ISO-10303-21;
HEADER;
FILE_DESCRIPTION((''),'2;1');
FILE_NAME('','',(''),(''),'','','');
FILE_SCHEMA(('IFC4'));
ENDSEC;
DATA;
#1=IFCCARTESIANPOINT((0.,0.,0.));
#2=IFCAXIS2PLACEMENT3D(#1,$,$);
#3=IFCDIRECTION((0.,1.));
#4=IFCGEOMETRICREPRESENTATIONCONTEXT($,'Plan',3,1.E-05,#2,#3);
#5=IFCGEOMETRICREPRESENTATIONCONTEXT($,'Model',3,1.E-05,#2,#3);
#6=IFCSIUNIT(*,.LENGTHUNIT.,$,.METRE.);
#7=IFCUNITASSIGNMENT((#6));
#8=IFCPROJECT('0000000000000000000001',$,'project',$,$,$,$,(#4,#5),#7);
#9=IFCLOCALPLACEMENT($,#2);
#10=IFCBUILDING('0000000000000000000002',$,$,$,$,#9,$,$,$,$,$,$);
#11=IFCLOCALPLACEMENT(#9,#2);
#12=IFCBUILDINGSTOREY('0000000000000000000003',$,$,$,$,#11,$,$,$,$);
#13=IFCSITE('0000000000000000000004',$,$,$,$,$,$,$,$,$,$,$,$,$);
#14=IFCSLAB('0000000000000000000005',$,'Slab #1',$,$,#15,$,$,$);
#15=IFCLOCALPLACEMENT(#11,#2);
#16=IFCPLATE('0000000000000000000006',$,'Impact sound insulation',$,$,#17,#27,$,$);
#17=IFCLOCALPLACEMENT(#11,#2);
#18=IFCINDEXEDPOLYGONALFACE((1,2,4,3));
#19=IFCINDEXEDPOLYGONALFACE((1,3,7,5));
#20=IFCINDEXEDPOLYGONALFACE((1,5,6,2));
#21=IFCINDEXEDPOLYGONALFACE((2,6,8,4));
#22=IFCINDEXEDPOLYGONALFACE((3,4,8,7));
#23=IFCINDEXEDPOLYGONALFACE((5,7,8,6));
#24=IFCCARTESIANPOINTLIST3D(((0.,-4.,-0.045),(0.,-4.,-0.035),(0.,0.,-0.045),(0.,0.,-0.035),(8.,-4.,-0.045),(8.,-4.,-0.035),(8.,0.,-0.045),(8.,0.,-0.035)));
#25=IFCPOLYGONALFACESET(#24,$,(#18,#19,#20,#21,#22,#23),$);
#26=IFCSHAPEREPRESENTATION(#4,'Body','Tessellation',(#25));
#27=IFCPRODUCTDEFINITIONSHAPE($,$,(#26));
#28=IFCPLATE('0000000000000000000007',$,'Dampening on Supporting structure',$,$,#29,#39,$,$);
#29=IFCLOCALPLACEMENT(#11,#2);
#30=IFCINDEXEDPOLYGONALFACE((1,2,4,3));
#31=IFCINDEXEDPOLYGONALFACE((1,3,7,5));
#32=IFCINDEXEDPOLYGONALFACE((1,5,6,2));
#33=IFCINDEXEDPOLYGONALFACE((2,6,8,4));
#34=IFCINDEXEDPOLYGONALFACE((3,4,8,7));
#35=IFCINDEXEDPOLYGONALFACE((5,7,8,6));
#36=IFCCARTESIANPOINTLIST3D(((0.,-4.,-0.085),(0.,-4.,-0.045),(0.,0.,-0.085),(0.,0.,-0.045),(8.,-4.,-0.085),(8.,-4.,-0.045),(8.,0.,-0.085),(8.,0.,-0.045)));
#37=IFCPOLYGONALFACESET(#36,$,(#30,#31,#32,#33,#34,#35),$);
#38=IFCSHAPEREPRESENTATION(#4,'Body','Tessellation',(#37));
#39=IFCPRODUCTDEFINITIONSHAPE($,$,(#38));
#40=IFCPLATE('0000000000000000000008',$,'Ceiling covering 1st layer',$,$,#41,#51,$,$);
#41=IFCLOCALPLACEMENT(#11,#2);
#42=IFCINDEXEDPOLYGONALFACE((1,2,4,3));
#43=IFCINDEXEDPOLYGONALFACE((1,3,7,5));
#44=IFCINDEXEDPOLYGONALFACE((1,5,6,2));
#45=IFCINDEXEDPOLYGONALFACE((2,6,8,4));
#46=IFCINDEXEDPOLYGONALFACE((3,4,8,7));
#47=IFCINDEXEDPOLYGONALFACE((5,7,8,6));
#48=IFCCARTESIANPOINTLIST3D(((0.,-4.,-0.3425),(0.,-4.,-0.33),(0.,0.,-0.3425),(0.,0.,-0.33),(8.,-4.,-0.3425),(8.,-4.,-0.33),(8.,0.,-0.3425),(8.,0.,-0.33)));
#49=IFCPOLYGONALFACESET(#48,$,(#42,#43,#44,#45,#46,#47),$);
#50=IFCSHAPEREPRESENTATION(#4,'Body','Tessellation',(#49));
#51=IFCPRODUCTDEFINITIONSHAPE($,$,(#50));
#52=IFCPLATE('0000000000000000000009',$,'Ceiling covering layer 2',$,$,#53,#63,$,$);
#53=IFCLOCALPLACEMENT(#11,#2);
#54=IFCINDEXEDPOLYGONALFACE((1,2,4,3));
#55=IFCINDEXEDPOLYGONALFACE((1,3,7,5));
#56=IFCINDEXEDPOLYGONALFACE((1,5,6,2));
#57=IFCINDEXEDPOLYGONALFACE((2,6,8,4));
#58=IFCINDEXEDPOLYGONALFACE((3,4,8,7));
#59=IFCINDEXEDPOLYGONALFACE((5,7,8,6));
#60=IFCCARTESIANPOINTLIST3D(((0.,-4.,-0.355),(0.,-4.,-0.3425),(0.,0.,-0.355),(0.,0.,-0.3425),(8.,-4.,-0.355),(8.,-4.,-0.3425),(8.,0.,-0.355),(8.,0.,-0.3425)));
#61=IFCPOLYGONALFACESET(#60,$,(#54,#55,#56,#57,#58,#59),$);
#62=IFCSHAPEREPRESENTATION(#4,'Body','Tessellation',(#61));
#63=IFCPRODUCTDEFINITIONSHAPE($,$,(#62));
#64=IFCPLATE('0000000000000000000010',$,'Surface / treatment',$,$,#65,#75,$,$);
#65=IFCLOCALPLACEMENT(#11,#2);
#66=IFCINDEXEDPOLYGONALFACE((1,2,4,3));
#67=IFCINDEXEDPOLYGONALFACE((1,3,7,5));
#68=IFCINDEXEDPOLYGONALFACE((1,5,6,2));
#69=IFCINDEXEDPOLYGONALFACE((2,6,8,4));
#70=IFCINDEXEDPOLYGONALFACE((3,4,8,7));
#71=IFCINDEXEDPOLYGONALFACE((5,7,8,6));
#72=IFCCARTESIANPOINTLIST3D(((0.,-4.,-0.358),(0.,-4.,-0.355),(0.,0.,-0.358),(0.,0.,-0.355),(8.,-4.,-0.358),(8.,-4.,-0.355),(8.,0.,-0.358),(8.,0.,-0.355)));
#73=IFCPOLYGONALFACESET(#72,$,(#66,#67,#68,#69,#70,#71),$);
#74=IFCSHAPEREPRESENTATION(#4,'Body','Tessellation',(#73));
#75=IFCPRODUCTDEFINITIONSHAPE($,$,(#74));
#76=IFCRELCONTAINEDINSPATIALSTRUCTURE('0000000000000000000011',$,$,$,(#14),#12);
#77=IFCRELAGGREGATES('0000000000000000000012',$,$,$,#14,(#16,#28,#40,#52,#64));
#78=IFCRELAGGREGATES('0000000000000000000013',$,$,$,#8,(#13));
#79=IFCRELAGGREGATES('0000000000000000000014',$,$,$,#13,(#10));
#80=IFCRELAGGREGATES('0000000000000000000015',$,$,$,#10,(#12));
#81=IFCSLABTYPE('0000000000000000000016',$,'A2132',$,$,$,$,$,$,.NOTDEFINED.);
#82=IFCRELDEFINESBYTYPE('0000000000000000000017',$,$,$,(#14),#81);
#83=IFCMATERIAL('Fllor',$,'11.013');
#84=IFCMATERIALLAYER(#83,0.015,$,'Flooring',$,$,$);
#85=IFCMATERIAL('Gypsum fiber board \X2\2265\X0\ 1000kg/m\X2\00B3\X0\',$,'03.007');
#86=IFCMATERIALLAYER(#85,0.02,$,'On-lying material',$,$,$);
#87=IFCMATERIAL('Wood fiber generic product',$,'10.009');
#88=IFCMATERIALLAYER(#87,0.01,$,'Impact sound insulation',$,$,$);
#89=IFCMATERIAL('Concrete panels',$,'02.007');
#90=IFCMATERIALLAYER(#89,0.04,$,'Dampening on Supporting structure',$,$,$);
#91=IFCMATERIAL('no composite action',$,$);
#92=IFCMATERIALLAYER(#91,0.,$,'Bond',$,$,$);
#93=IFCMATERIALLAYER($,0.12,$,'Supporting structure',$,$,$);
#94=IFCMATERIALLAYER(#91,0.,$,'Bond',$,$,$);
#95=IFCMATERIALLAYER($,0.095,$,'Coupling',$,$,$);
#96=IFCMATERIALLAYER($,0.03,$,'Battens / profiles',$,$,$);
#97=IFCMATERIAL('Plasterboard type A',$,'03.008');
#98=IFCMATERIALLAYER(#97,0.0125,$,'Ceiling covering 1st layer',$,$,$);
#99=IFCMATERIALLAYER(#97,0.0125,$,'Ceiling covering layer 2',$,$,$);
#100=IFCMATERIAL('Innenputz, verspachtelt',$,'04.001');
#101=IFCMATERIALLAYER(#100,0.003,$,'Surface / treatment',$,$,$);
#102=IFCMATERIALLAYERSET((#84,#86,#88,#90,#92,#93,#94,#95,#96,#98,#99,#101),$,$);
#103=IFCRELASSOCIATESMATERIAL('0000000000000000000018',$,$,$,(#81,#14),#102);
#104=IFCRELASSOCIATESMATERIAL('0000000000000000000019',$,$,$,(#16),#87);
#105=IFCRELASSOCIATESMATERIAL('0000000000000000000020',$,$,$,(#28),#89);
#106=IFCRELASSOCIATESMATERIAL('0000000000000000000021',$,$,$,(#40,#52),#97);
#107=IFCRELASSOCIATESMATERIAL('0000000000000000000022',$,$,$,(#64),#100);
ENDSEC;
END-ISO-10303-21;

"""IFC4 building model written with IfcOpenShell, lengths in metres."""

from ifc_helpers import new_model, si_unit, direction, frame, frame_2d, origin, place, context, project, spatial, rectangle, extrude, material, layer, layer_set, type_object, element, aggregate, save


model = new_model("IFC4")

# Units and contexts
plan_context = context("Plan", 3, precision=1e-05, world=origin(), true_north=direction((0.0, 1.0)))
model_context = context("Model", 3, precision=1e-05, world=origin(), true_north=direction((0.0, 1.0)))
ifc_project = project(units=[si_unit("LENGTHUNIT", "METRE")], contexts=[plan_context, model_context])

# Site, building, storey
site = spatial("IfcSite", under=ifc_project)
building_placement = place(None, origin())
building = spatial("IfcBuilding", under=site, at=building_placement)
storey_placement = place(building_placement, origin())
storey = spatial("IfcBuildingStorey", under=building, at=storey_placement)

# Slab, plates
ifc_material_1 = material(Name="Fllor", Category="11.013")
ifc_layer_1 = layer(ifc_material_1, 0.015, Name="Flooring")
ifc_material_2 = material(Name="Gypsum fiber board ≥ 1000kg/m³", Category="03.007")
ifc_layer_2 = layer(ifc_material_2, 0.02, Name="On-lying material")
ifc_material_3 = material(Name="Wood fiber generic product", Category="10.009")
ifc_layer_3 = layer(ifc_material_3, 0.01, Name="Impact sound insulation")
ifc_material_4 = material(Name="Concrete panels", Category="02.007")
ifc_layer_4 = layer(ifc_material_4, 0.04, Name="Dampening on Supporting structure")
ifc_material_5 = material(Name="no composite action")
ifc_layer_5 = layer(ifc_material_5, 0.0, Name="Bond")
ifc_layer_6 = layer(None, 0.12, Name="Supporting structure")
ifc_layer_7 = layer(ifc_material_5, 0.0, Name="Bond")
ifc_layer_8 = layer(None, 0.095, Name="Coupling")
ifc_layer_9 = layer(None, 0.03, Name="Battens / profiles")
ifc_material_6 = material(Name="Plasterboard type A", Category="03.008")
ifc_layer_10 = layer(ifc_material_6, 0.0125, Name="Ceiling covering 1st layer")
ifc_layer_11 = layer(ifc_material_6, 0.0125, Name="Ceiling covering layer 2")
ifc_material_7 = material(Name="Innenputz, verspachtelt", Category="04.001")
ifc_layer_12 = layer(ifc_material_7, 0.003, Name="Surface / treatment")
ifc_layer_set = layer_set([ifc_layer_1, ifc_layer_2, ifc_layer_3, ifc_layer_4, ifc_layer_5, ifc_layer_6, ifc_layer_7, ifc_layer_8, ifc_layer_9, ifc_layer_10, ifc_layer_11, ifc_layer_12])
slab_type = type_object("IfcSlabType", Name="A2132", PredefinedType="NOTDEFINED", material=ifc_layer_set)
slab_placement = place(None, frame((0.0, 0.0, 0.0), z_axis=(0.0, 0.0, -1.0), x_axis=(1.0, 0.0, 0.0)))
slab = element("IfcSlab", 1, at=slab_placement, inside=storey, type_object=slab_type, material=ifc_layer_set, Name="Slab #1")
plate_1_placement = place(slab_placement, origin())
plate_1 = element("IfcPlate", 2, at=plate_1_placement, material=ifc_material_3, Name="Impact sound insulation", context=plan_context, shape_type="SweptSolid", body=[
    extrude(rectangle(XDim=8.0, YDim=4.0, at=frame_2d((4.0, 2.0), x_axis=(1.0, 0.0))), frame((0.0, 0.0, 0.035), z_axis=(0.0, 0.0, 1.0), x_axis=(1.0, 0.0, 0.0)), (0.0, 0.0, 1.0), 0.01),
])
plate_2_placement = place(slab_placement, origin())
plate_2 = element("IfcPlate", 3, at=plate_2_placement, material=ifc_material_4, Name="Dampening on Supporting structure", context=plan_context, shape_type="SweptSolid", body=[
    extrude(rectangle(XDim=8.0, YDim=4.0, at=frame_2d((4.0, 2.0), x_axis=(1.0, 0.0))), frame((0.0, 0.0, 0.045), z_axis=(0.0, 0.0, 1.0), x_axis=(1.0, 0.0, 0.0)), (0.0, 0.0, 1.0), 0.04),
])
plate_3_placement = place(slab_placement, origin())
plate_3 = element("IfcPlate", 4, at=plate_3_placement, material=ifc_material_6, Name="Ceiling covering 1st layer", context=plan_context, shape_type="SweptSolid", body=[
    extrude(rectangle(XDim=8.0, YDim=4.0, at=frame_2d((4.0, 2.0), x_axis=(1.0, 0.0))), frame((0.0, 0.0, 0.33), z_axis=(0.0, 0.0, 1.0), x_axis=(1.0, 0.0, 0.0)), (0.0, 0.0, 1.0), 0.0125),
])
plate_4_placement = place(slab_placement, origin())
plate_4 = element("IfcPlate", 5, at=plate_4_placement, material=ifc_material_6, Name="Ceiling covering layer 2", context=plan_context, shape_type="SweptSolid", body=[
    extrude(rectangle(XDim=8.0, YDim=4.0, at=frame_2d((4.0, 2.0), x_axis=(1.0, 0.0))), frame((0.0, 0.0, 0.3425), z_axis=(0.0, 0.0, 1.0), x_axis=(1.0, 0.0, 0.0)), (0.0, 0.0, 1.0), 0.0125),
])
plate_5_placement = place(slab_placement, origin())
plate_5 = element("IfcPlate", 6, at=plate_5_placement, material=ifc_material_7, Name="Surface / treatment", context=plan_context, shape_type="SweptSolid", body=[
    extrude(rectangle(XDim=8.0, YDim=4.0, at=frame_2d((4.0, 2.0), x_axis=(1.0, 0.0))), frame((0.0, 0.0, 0.355), z_axis=(0.0, 0.0, 1.0), x_axis=(1.0, 0.0, 0.0)), (0.0, 0.0, 1.0), 0.003),
])
aggregate(slab, [plate_1, plate_2, plate_3, plate_4, plate_5])

save(model, "model.ifc")
